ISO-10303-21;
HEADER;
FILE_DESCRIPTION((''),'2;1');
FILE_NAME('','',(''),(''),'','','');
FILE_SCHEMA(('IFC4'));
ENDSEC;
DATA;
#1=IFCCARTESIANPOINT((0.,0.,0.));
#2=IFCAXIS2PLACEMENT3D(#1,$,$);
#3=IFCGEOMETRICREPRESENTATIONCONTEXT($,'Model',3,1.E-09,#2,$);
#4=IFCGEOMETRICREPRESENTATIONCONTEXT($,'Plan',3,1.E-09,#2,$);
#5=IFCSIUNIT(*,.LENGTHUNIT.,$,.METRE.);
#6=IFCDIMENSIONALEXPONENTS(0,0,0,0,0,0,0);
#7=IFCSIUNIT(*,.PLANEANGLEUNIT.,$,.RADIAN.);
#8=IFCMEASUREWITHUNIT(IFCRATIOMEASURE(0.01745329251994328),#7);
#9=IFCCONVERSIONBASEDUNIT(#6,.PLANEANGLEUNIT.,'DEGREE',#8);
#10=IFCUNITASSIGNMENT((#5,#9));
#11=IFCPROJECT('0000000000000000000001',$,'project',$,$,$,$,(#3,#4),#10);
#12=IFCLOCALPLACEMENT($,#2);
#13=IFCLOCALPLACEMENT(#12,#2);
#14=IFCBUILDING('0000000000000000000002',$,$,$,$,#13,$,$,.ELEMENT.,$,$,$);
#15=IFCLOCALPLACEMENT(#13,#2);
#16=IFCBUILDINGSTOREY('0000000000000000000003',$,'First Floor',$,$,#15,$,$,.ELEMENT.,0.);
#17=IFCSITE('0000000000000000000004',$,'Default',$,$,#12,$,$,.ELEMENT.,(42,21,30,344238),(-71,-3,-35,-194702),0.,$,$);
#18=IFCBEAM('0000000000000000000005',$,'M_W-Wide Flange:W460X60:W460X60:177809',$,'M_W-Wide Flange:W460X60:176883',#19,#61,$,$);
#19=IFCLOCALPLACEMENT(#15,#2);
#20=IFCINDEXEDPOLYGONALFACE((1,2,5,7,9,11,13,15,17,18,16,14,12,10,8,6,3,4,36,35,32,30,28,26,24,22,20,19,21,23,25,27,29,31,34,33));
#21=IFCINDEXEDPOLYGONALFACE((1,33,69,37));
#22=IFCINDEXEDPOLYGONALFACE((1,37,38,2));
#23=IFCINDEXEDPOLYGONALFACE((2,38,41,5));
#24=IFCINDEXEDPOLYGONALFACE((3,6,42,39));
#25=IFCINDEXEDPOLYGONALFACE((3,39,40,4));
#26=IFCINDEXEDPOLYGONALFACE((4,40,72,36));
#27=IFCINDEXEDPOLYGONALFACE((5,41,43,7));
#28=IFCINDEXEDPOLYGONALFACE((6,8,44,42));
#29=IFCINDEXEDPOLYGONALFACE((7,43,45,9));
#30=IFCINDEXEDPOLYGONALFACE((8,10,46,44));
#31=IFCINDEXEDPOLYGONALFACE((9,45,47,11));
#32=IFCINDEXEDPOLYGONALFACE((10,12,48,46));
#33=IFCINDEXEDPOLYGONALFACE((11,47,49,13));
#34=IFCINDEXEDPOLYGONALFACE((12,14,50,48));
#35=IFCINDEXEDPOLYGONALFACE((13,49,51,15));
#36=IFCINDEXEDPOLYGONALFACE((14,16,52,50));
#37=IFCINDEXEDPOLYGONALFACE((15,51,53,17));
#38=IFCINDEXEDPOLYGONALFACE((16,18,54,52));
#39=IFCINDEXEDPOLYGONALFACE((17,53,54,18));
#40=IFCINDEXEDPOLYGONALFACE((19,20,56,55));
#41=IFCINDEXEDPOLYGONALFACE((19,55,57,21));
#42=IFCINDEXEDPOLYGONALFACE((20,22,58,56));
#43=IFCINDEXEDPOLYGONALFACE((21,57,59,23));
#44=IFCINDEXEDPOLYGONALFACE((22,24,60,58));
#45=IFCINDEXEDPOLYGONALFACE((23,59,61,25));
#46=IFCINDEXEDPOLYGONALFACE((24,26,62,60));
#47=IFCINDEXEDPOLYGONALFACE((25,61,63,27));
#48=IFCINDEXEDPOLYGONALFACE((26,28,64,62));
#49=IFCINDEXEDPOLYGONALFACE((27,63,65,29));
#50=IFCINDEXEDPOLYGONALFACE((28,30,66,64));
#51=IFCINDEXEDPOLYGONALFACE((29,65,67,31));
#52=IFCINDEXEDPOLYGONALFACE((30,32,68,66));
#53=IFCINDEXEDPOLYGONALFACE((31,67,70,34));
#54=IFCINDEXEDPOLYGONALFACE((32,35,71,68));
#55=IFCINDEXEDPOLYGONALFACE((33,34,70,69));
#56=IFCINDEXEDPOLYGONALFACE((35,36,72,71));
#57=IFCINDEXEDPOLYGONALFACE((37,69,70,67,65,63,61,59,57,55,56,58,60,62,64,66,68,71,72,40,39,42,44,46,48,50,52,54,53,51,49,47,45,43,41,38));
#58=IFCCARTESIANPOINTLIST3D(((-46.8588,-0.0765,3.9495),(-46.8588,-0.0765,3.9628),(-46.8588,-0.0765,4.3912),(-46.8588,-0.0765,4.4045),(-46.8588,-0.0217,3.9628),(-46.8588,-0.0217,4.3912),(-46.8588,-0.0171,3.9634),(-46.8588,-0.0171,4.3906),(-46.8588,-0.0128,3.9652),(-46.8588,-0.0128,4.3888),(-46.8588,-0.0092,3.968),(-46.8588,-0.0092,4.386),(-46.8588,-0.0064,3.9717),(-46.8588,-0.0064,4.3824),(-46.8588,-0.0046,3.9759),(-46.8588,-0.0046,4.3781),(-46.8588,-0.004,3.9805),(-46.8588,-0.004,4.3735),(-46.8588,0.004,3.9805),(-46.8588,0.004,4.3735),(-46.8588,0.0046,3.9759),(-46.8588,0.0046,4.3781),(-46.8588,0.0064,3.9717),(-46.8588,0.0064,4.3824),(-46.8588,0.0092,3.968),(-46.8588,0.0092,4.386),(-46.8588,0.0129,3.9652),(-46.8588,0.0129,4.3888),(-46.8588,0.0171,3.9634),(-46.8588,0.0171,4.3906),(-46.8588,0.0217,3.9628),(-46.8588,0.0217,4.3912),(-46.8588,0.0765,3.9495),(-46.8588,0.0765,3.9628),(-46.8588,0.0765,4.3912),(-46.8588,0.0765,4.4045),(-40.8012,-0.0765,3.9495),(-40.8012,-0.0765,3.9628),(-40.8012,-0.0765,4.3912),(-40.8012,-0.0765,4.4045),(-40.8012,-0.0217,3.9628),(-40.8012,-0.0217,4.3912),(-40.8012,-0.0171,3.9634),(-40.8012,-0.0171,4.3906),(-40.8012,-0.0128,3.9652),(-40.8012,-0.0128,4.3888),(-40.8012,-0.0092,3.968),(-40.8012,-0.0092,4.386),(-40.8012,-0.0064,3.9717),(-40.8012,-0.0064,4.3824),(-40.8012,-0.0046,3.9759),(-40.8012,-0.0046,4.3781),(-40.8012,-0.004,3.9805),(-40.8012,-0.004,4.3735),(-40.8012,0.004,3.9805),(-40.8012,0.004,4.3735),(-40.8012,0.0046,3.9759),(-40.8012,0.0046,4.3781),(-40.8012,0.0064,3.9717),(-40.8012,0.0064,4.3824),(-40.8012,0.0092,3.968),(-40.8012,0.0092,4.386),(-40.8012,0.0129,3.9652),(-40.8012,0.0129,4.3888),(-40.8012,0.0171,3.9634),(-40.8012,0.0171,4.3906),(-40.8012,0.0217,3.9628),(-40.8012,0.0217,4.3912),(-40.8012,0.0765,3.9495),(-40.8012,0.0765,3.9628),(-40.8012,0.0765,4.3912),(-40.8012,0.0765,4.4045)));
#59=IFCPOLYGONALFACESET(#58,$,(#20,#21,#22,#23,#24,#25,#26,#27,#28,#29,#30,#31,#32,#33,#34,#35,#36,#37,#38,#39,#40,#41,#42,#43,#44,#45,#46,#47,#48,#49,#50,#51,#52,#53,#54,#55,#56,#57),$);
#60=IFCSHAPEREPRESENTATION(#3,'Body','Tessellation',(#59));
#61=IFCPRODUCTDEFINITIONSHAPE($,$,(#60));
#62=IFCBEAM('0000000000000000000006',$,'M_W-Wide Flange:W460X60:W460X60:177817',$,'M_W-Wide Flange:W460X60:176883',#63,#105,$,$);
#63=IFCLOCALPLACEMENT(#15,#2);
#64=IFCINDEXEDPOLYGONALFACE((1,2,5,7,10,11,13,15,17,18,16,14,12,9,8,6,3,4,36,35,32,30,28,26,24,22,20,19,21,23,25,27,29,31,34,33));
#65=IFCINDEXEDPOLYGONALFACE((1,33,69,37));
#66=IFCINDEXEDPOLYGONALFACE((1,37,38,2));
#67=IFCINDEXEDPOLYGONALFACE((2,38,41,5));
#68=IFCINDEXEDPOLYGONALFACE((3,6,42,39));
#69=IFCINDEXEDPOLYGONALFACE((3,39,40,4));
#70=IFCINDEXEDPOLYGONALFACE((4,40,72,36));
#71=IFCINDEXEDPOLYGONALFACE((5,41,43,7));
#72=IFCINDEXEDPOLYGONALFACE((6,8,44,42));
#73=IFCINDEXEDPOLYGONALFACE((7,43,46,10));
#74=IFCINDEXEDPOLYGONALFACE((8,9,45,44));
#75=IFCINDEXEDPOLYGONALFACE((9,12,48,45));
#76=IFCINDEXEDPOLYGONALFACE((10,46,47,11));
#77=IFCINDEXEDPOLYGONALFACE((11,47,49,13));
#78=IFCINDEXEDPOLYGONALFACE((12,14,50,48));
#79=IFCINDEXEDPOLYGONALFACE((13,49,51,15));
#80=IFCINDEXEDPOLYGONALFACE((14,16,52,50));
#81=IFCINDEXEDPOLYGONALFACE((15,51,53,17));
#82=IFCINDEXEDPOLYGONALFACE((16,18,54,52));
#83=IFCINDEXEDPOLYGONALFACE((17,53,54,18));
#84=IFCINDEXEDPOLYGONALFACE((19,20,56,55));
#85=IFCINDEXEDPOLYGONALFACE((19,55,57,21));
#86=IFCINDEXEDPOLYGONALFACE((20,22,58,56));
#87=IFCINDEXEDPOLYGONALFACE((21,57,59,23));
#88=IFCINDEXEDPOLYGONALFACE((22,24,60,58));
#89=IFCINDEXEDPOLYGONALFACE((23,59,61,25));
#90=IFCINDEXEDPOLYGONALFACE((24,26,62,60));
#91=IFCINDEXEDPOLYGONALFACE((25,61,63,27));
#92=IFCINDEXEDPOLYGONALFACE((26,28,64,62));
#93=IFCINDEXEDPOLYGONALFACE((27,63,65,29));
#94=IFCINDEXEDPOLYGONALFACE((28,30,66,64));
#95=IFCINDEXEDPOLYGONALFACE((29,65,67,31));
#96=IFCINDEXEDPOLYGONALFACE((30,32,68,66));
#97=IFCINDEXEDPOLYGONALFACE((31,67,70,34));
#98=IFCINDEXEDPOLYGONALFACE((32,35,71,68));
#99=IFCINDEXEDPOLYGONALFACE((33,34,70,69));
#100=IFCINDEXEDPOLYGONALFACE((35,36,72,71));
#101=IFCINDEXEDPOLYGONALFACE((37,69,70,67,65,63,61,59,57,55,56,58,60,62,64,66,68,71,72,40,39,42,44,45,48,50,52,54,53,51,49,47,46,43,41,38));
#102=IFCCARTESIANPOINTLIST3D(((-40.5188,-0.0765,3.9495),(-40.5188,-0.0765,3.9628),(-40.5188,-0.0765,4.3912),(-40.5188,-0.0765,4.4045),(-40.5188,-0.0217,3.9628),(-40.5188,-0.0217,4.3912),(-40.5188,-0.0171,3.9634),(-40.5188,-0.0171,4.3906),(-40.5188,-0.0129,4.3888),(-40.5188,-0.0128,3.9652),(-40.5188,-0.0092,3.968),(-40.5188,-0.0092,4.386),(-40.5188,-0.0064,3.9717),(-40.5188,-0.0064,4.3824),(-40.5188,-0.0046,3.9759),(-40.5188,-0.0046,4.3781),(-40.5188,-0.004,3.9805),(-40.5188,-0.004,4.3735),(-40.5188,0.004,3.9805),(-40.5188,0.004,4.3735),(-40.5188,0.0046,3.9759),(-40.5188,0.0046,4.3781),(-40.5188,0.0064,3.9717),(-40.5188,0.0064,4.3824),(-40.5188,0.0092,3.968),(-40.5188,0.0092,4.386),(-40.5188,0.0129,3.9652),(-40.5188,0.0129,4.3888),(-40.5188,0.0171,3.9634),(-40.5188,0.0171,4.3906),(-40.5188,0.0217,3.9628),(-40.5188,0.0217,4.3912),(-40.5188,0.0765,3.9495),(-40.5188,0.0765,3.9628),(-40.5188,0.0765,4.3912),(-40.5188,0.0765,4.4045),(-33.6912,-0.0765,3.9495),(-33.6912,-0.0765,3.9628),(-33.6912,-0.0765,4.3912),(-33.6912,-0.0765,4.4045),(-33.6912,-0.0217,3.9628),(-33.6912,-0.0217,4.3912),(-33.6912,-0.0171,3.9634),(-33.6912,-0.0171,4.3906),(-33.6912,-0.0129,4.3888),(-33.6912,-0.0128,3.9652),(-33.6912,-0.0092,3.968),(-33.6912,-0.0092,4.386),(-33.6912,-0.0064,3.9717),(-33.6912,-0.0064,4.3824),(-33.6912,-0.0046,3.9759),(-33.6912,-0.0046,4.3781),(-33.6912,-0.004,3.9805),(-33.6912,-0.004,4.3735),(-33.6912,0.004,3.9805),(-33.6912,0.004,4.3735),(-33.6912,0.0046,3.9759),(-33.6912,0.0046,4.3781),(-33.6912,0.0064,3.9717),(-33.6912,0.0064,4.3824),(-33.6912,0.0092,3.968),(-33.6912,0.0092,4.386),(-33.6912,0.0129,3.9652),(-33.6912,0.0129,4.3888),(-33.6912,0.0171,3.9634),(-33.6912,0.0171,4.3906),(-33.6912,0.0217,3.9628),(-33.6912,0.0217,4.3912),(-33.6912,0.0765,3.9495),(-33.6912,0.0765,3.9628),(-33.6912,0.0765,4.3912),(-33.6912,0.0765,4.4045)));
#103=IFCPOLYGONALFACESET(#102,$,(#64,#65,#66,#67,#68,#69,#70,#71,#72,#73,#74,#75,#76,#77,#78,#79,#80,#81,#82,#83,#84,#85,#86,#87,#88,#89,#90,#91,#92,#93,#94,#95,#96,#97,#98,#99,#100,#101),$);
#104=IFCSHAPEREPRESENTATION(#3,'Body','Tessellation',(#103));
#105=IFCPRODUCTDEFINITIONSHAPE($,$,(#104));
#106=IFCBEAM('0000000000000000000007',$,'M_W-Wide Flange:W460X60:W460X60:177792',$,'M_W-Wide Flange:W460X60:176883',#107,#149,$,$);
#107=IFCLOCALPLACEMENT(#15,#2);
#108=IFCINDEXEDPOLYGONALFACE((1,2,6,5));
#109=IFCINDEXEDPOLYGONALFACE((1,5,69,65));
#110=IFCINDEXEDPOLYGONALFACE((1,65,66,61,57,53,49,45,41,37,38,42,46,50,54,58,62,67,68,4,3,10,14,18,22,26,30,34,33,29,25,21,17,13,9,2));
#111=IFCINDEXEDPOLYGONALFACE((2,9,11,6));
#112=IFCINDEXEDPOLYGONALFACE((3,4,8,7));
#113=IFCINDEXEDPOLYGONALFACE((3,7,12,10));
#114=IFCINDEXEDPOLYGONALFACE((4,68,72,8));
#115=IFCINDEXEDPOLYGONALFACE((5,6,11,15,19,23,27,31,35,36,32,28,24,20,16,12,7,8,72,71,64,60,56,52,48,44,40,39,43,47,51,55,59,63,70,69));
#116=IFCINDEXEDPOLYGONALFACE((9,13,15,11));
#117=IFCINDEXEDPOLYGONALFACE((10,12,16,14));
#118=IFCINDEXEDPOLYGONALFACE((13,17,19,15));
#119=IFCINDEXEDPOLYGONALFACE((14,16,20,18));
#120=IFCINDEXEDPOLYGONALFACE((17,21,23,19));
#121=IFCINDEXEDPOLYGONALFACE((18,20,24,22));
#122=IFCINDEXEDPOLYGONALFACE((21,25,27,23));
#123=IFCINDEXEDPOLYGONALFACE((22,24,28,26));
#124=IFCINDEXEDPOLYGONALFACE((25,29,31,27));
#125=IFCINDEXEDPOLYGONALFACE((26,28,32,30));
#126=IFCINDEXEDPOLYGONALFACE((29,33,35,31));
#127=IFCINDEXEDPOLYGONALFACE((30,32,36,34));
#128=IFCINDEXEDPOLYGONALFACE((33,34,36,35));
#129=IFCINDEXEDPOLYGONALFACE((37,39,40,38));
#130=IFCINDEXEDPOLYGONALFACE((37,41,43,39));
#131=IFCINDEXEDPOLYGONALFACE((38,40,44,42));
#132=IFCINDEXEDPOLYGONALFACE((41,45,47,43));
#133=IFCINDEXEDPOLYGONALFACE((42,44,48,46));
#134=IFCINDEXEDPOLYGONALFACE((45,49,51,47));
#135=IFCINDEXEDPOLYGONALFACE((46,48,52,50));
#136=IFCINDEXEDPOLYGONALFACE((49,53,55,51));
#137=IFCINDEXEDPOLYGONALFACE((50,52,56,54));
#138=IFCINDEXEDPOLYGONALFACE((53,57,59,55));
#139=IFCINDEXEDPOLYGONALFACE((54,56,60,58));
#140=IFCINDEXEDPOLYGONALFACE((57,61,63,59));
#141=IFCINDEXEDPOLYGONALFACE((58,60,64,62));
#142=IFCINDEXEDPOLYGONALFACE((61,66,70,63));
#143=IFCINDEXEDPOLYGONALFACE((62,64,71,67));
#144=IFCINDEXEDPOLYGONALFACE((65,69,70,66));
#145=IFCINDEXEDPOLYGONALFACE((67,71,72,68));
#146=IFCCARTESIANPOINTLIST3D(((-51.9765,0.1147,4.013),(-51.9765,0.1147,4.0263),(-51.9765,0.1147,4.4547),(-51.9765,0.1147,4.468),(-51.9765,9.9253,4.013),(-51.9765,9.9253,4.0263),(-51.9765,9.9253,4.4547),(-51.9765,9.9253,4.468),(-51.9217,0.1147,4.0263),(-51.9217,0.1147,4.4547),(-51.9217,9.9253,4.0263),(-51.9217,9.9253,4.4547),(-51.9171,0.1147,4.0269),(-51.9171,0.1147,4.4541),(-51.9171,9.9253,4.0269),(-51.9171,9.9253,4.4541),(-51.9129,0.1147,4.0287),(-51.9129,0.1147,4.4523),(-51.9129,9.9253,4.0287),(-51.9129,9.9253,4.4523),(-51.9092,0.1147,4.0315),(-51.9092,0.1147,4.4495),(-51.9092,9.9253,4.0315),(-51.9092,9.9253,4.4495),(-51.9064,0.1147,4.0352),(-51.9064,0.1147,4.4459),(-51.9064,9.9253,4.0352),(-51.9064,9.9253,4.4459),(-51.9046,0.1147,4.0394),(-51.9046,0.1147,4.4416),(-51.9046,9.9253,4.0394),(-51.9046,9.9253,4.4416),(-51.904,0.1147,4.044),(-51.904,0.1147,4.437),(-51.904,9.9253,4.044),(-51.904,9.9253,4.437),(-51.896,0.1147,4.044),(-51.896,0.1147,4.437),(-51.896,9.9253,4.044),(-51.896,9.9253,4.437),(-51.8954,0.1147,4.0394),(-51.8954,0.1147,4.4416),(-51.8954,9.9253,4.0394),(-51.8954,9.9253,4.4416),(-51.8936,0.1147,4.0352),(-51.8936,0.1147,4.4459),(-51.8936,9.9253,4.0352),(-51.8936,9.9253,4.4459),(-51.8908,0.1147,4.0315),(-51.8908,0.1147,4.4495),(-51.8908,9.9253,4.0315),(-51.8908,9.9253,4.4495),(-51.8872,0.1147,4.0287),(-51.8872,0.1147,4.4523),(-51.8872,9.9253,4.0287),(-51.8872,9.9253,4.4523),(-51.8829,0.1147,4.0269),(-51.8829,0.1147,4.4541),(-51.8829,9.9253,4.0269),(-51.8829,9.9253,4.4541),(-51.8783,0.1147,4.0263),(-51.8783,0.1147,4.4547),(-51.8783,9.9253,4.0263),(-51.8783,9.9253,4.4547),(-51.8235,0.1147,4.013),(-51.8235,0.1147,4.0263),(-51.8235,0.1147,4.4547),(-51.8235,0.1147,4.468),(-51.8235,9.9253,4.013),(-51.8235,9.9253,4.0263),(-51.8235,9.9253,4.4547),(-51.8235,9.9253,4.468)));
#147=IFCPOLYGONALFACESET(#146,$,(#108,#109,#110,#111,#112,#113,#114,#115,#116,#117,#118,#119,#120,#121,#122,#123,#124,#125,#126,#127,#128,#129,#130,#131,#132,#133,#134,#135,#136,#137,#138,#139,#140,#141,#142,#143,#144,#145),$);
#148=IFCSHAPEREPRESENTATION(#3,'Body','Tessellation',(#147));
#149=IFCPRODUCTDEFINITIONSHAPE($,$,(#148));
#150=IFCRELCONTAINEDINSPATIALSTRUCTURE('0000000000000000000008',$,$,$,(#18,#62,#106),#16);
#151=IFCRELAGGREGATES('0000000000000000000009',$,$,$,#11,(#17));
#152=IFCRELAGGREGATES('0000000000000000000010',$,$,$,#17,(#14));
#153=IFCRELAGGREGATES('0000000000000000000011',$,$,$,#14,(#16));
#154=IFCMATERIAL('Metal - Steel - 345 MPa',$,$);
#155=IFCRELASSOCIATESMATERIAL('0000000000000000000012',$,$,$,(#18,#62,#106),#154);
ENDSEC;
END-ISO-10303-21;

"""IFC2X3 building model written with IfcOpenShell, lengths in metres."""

from ifc_helpers import new_model, entity, si_unit, converted_unit, frame, frame_2d, origin, place, context, project, spatial, polyline, circle_curve, parameter, trimmed, segment, composite_curve, outline, extrude, material, element, save


model = new_model("IFC2X3")

# Units and contexts
model_context = context("Model", 3, precision=1e-09, world=origin())
plan_context = context("Plan", 3, precision=1e-09, world=origin())
ifc_project = project(units=[si_unit("LENGTHUNIT", "METRE"), converted_unit("PLANEANGLEUNIT", "DEGREE", entity("IfcRatioMeasure", 0.01745329251994328), si_unit("PLANEANGLEUNIT", "RADIAN"), dimensions=[0, 0, 0, 0, 0, 0, 0])], contexts=[model_context, plan_context])

# Site, building, storey
site_placement = place(None, origin())
site = spatial("IfcSite", under=ifc_project, at=site_placement, Name="Default", CompositionType="ELEMENT", RefLatitude=(42, 21, 30, 344238), RefLongitude=(-71, -3, -35, -194702), RefElevation=0.0)
building_placement = place(site_placement, origin())
building = spatial("IfcBuilding", under=site, at=building_placement, CompositionType="ELEMENT")
storey_placement = place(building_placement, origin())
storey = spatial("IfcBuildingStorey", under=building, at=storey_placement, Name="First Floor", CompositionType="ELEMENT", Elevation=0.0)

# Beams
ifc_material_1 = material(Name="Metal - Steel - 345 MPa")
beam_1_placement = place(storey_placement, frame((-47.0022, 0.0, 4.4045), z_axis=(0.0, 0.0, 1.0), x_axis=(0.0, -1.0, 0.0)))
element("IfcBeam", 1, at=beam_1_placement, inside=storey, material=ifc_material_1, Name="M_W-Wide Flange:W460X60:W460X60:177809", ObjectType="M_W-Wide Flange:W460X60:176883", context=model_context, shape_type="SweptSolid", body=[
    extrude(outline(composite_curve([segment(polyline([(-0.0765, -0.2142), (-0.0765, -0.2275)]), True, "CONTINUOUS"), segment(polyline([(-0.0765, -0.2275), (0.0765, -0.2275)]), True, "CONTINUOUS"), segment(polyline([(0.0765, -0.2275), (0.0765, -0.2142)]), True, "CONTINUOUS"), segment(polyline([(0.0765, -0.2142), (0.0217, -0.2142)]), True, "CONTINUOUS"), segment(trimmed(circle_curve(frame_2d((0.0217, -0.1965), x_axis=(1.0, 0.0)), 0.0177), [parameter(180.0)], [parameter(270.0)], True, "PARAMETER"), False, "CONTINUOUS"), segment(polyline([(0.004, -0.1965), (0.004, 0.1965)]), True, "CONTINUOUS"), segment(trimmed(circle_curve(frame_2d((0.0217, 0.1965), x_axis=(1.0, 0.0)), 0.0177), [parameter(90.0)], [parameter(180.0)], True, "PARAMETER"), False, "CONTINUOUS"), segment(polyline([(0.0217, 0.2142), (0.0765, 0.2142)]), True, "CONTINUOUS"), segment(polyline([(0.0765, 0.2142), (0.0765, 0.2275)]), True, "CONTINUOUS"), segment(polyline([(0.0765, 0.2275), (-0.0765, 0.2275)]), True, "CONTINUOUS"), segment(polyline([(-0.0765, 0.2275), (-0.0765, 0.2142)]), True, "CONTINUOUS"), segment(polyline([(-0.0765, 0.2142), (-0.0217, 0.2142)]), True, "CONTINUOUS"), segment(trimmed(circle_curve(frame_2d((-0.0217, 0.1965), x_axis=(1.0, 0.0)), 0.0177), [parameter(360.0)], [parameter(90.0)], True, "PARAMETER"), False, "CONTINUOUS"), segment(polyline([(-0.004, 0.1965), (-0.004, -0.1965)]), True, "CONTINUOUS"), segment(trimmed(circle_curve(frame_2d((-0.0217, -0.1965), x_axis=(1.0, 0.0)), 0.0177), [parameter(270.0)], [parameter(0.0)], True, "PARAMETER"), False, "CONTINUOUS"), segment(polyline([(-0.0217, -0.2142), (-0.0765, -0.2142)]), True, "CONTINUOUS")], self_intersect=False)), frame((0.0, 0.1434, -0.2275), z_axis=(0.0, -1.0, 0.0), x_axis=(1.0, 0.0, 0.0)), (0.0, 0.0, -1.0), 6.0576),
])
beam_2_placement = place(storey_placement, frame((-40.6619, 0.0, 4.4045), z_axis=(0.0, 0.0, 1.0), x_axis=(0.0, -1.0, 0.0)))
element("IfcBeam", 2, at=beam_2_placement, inside=storey, material=ifc_material_1, Name="M_W-Wide Flange:W460X60:W460X60:177817", ObjectType="M_W-Wide Flange:W460X60:176883", context=model_context, shape_type="SweptSolid", body=[
    extrude(outline(composite_curve([segment(polyline([(-0.0765, -0.2142), (-0.0765, -0.2275)]), True, "CONTINUOUS"), segment(polyline([(-0.0765, -0.2275), (0.0765, -0.2275)]), True, "CONTINUOUS"), segment(polyline([(0.0765, -0.2275), (0.0765, -0.2142)]), True, "CONTINUOUS"), segment(polyline([(0.0765, -0.2142), (0.0217, -0.2142)]), True, "CONTINUOUS"), segment(trimmed(circle_curve(frame_2d((0.0217, -0.1965), x_axis=(0.0, -1.0)), 0.0177), [parameter(270.0)], [parameter(360.0)], True, "PARAMETER"), False, "CONTINUOUS"), segment(polyline([(0.004, -0.1965), (0.004, 0.1965)]), True, "CONTINUOUS"), segment(trimmed(circle_curve(frame_2d((0.0217, 0.1965), x_axis=(-1.0, 0.0)), 0.0177), [parameter(270.0)], [parameter(360.0)], True, "PARAMETER"), False, "CONTINUOUS"), segment(polyline([(0.0217, 0.2142), (0.0765, 0.2142)]), True, "CONTINUOUS"), segment(polyline([(0.0765, 0.2142), (0.0765, 0.2275)]), True, "CONTINUOUS"), segment(polyline([(0.0765, 0.2275), (-0.0765, 0.2275)]), True, "CONTINUOUS"), segment(polyline([(-0.0765, 0.2275), (-0.0765, 0.2142)]), True, "CONTINUOUS"), segment(polyline([(-0.0765, 0.2142), (-0.0217, 0.2142)]), True, "CONTINUOUS"), segment(trimmed(circle_curve(frame_2d((-0.0217, 0.1965), x_axis=(0.0, 1.0)), 0.0177), [parameter(270.0)], [parameter(360.0)], True, "PARAMETER"), False, "CONTINUOUS"), segment(polyline([(-0.004, 0.1965), (-0.004, -0.1965)]), True, "CONTINUOUS"), segment(trimmed(circle_curve(frame_2d((-0.0217, -0.1965), x_axis=(1.0, 0.0)), 0.0177), [parameter(270.0)], [parameter(0.0)], True, "PARAMETER"), False, "CONTINUOUS"), segment(polyline([(-0.0217, -0.2142), (-0.0765, -0.2142)]), True, "CONTINUOUS")], self_intersect=False)), frame((0.0, 0.1431, -0.2275), z_axis=(0.0, -1.0, 0.0), x_axis=(1.0, 0.0, 0.0)), (0.0, 0.0, -1.0), 6.8276),
])
beam_3_placement = place(storey_placement, frame((-51.9, 10.0414, 4.468), z_axis=(0.0, 0.0, 1.0), x_axis=(-1.0, 0.0, 0.0)))
element("IfcBeam", 3, at=beam_3_placement, inside=storey, material=ifc_material_1, Name="M_W-Wide Flange:W460X60:W460X60:177792", ObjectType="M_W-Wide Flange:W460X60:176883", context=model_context, shape_type="SweptSolid", body=[
    extrude(outline(composite_curve([segment(polyline([(0.2142, -0.0765), (0.2275, -0.0765)]), True, "CONTINUOUS"), segment(polyline([(0.2275, -0.0765), (0.2275, 0.0765)]), True, "CONTINUOUS"), segment(polyline([(0.2275, 0.0765), (0.2142, 0.0765)]), True, "CONTINUOUS"), segment(polyline([(0.2142, 0.0765), (0.2142, 0.0217)]), True, "CONTINUOUS"), segment(trimmed(circle_curve(frame_2d((0.1965, 0.0217), x_axis=(1.0, 0.0)), 0.0177), [parameter(270.0)], [parameter(360.0)], True, "PARAMETER"), False, "CONTINUOUS"), segment(polyline([(0.1965, 0.004), (-0.1965, 0.004)]), True, "CONTINUOUS"), segment(trimmed(circle_curve(frame_2d((-0.1965, 0.0217), x_axis=(0.0, -1.0)), 0.0177), [parameter(270.0)], [parameter(360.0)], True, "PARAMETER"), False, "CONTINUOUS"), segment(polyline([(-0.2142, 0.0217), (-0.2142, 0.0765)]), True, "CONTINUOUS"), segment(polyline([(-0.2142, 0.0765), (-0.2275, 0.0765)]), True, "CONTINUOUS"), segment(polyline([(-0.2275, 0.0765), (-0.2275, -0.0765)]), True, "CONTINUOUS"), segment(polyline([(-0.2275, -0.0765), (-0.2142, -0.0765)]), True, "CONTINUOUS"), segment(polyline([(-0.2142, -0.0765), (-0.2142, -0.0217)]), True, "CONTINUOUS"), segment(trimmed(circle_curve(frame_2d((-0.1965, -0.0217), x_axis=(-1.0, 0.0)), 0.0177), [parameter(270.0)], [parameter(360.0)], True, "PARAMETER"), False, "CONTINUOUS"), segment(polyline([(-0.1965, -0.004), (0.1965, -0.004)]), True, "CONTINUOUS"), segment(trimmed(circle_curve(frame_2d((0.1965, -0.0217), x_axis=(0.0, 1.0)), 0.0177), [parameter(270.0)], [parameter(0.0)], True, "PARAMETER"), False, "CONTINUOUS"), segment(polyline([(0.2142, -0.0217), (0.2142, -0.0765)]), True, "CONTINUOUS")], self_intersect=False)), frame((0.0, 9.9267, -0.2275), z_axis=(0.0, -1.0, 0.0), x_axis=(0.0, 0.0, -1.0)), (0.0, 0.0, 1.0), 9.8106),
])

save(model, "model.ifc")
